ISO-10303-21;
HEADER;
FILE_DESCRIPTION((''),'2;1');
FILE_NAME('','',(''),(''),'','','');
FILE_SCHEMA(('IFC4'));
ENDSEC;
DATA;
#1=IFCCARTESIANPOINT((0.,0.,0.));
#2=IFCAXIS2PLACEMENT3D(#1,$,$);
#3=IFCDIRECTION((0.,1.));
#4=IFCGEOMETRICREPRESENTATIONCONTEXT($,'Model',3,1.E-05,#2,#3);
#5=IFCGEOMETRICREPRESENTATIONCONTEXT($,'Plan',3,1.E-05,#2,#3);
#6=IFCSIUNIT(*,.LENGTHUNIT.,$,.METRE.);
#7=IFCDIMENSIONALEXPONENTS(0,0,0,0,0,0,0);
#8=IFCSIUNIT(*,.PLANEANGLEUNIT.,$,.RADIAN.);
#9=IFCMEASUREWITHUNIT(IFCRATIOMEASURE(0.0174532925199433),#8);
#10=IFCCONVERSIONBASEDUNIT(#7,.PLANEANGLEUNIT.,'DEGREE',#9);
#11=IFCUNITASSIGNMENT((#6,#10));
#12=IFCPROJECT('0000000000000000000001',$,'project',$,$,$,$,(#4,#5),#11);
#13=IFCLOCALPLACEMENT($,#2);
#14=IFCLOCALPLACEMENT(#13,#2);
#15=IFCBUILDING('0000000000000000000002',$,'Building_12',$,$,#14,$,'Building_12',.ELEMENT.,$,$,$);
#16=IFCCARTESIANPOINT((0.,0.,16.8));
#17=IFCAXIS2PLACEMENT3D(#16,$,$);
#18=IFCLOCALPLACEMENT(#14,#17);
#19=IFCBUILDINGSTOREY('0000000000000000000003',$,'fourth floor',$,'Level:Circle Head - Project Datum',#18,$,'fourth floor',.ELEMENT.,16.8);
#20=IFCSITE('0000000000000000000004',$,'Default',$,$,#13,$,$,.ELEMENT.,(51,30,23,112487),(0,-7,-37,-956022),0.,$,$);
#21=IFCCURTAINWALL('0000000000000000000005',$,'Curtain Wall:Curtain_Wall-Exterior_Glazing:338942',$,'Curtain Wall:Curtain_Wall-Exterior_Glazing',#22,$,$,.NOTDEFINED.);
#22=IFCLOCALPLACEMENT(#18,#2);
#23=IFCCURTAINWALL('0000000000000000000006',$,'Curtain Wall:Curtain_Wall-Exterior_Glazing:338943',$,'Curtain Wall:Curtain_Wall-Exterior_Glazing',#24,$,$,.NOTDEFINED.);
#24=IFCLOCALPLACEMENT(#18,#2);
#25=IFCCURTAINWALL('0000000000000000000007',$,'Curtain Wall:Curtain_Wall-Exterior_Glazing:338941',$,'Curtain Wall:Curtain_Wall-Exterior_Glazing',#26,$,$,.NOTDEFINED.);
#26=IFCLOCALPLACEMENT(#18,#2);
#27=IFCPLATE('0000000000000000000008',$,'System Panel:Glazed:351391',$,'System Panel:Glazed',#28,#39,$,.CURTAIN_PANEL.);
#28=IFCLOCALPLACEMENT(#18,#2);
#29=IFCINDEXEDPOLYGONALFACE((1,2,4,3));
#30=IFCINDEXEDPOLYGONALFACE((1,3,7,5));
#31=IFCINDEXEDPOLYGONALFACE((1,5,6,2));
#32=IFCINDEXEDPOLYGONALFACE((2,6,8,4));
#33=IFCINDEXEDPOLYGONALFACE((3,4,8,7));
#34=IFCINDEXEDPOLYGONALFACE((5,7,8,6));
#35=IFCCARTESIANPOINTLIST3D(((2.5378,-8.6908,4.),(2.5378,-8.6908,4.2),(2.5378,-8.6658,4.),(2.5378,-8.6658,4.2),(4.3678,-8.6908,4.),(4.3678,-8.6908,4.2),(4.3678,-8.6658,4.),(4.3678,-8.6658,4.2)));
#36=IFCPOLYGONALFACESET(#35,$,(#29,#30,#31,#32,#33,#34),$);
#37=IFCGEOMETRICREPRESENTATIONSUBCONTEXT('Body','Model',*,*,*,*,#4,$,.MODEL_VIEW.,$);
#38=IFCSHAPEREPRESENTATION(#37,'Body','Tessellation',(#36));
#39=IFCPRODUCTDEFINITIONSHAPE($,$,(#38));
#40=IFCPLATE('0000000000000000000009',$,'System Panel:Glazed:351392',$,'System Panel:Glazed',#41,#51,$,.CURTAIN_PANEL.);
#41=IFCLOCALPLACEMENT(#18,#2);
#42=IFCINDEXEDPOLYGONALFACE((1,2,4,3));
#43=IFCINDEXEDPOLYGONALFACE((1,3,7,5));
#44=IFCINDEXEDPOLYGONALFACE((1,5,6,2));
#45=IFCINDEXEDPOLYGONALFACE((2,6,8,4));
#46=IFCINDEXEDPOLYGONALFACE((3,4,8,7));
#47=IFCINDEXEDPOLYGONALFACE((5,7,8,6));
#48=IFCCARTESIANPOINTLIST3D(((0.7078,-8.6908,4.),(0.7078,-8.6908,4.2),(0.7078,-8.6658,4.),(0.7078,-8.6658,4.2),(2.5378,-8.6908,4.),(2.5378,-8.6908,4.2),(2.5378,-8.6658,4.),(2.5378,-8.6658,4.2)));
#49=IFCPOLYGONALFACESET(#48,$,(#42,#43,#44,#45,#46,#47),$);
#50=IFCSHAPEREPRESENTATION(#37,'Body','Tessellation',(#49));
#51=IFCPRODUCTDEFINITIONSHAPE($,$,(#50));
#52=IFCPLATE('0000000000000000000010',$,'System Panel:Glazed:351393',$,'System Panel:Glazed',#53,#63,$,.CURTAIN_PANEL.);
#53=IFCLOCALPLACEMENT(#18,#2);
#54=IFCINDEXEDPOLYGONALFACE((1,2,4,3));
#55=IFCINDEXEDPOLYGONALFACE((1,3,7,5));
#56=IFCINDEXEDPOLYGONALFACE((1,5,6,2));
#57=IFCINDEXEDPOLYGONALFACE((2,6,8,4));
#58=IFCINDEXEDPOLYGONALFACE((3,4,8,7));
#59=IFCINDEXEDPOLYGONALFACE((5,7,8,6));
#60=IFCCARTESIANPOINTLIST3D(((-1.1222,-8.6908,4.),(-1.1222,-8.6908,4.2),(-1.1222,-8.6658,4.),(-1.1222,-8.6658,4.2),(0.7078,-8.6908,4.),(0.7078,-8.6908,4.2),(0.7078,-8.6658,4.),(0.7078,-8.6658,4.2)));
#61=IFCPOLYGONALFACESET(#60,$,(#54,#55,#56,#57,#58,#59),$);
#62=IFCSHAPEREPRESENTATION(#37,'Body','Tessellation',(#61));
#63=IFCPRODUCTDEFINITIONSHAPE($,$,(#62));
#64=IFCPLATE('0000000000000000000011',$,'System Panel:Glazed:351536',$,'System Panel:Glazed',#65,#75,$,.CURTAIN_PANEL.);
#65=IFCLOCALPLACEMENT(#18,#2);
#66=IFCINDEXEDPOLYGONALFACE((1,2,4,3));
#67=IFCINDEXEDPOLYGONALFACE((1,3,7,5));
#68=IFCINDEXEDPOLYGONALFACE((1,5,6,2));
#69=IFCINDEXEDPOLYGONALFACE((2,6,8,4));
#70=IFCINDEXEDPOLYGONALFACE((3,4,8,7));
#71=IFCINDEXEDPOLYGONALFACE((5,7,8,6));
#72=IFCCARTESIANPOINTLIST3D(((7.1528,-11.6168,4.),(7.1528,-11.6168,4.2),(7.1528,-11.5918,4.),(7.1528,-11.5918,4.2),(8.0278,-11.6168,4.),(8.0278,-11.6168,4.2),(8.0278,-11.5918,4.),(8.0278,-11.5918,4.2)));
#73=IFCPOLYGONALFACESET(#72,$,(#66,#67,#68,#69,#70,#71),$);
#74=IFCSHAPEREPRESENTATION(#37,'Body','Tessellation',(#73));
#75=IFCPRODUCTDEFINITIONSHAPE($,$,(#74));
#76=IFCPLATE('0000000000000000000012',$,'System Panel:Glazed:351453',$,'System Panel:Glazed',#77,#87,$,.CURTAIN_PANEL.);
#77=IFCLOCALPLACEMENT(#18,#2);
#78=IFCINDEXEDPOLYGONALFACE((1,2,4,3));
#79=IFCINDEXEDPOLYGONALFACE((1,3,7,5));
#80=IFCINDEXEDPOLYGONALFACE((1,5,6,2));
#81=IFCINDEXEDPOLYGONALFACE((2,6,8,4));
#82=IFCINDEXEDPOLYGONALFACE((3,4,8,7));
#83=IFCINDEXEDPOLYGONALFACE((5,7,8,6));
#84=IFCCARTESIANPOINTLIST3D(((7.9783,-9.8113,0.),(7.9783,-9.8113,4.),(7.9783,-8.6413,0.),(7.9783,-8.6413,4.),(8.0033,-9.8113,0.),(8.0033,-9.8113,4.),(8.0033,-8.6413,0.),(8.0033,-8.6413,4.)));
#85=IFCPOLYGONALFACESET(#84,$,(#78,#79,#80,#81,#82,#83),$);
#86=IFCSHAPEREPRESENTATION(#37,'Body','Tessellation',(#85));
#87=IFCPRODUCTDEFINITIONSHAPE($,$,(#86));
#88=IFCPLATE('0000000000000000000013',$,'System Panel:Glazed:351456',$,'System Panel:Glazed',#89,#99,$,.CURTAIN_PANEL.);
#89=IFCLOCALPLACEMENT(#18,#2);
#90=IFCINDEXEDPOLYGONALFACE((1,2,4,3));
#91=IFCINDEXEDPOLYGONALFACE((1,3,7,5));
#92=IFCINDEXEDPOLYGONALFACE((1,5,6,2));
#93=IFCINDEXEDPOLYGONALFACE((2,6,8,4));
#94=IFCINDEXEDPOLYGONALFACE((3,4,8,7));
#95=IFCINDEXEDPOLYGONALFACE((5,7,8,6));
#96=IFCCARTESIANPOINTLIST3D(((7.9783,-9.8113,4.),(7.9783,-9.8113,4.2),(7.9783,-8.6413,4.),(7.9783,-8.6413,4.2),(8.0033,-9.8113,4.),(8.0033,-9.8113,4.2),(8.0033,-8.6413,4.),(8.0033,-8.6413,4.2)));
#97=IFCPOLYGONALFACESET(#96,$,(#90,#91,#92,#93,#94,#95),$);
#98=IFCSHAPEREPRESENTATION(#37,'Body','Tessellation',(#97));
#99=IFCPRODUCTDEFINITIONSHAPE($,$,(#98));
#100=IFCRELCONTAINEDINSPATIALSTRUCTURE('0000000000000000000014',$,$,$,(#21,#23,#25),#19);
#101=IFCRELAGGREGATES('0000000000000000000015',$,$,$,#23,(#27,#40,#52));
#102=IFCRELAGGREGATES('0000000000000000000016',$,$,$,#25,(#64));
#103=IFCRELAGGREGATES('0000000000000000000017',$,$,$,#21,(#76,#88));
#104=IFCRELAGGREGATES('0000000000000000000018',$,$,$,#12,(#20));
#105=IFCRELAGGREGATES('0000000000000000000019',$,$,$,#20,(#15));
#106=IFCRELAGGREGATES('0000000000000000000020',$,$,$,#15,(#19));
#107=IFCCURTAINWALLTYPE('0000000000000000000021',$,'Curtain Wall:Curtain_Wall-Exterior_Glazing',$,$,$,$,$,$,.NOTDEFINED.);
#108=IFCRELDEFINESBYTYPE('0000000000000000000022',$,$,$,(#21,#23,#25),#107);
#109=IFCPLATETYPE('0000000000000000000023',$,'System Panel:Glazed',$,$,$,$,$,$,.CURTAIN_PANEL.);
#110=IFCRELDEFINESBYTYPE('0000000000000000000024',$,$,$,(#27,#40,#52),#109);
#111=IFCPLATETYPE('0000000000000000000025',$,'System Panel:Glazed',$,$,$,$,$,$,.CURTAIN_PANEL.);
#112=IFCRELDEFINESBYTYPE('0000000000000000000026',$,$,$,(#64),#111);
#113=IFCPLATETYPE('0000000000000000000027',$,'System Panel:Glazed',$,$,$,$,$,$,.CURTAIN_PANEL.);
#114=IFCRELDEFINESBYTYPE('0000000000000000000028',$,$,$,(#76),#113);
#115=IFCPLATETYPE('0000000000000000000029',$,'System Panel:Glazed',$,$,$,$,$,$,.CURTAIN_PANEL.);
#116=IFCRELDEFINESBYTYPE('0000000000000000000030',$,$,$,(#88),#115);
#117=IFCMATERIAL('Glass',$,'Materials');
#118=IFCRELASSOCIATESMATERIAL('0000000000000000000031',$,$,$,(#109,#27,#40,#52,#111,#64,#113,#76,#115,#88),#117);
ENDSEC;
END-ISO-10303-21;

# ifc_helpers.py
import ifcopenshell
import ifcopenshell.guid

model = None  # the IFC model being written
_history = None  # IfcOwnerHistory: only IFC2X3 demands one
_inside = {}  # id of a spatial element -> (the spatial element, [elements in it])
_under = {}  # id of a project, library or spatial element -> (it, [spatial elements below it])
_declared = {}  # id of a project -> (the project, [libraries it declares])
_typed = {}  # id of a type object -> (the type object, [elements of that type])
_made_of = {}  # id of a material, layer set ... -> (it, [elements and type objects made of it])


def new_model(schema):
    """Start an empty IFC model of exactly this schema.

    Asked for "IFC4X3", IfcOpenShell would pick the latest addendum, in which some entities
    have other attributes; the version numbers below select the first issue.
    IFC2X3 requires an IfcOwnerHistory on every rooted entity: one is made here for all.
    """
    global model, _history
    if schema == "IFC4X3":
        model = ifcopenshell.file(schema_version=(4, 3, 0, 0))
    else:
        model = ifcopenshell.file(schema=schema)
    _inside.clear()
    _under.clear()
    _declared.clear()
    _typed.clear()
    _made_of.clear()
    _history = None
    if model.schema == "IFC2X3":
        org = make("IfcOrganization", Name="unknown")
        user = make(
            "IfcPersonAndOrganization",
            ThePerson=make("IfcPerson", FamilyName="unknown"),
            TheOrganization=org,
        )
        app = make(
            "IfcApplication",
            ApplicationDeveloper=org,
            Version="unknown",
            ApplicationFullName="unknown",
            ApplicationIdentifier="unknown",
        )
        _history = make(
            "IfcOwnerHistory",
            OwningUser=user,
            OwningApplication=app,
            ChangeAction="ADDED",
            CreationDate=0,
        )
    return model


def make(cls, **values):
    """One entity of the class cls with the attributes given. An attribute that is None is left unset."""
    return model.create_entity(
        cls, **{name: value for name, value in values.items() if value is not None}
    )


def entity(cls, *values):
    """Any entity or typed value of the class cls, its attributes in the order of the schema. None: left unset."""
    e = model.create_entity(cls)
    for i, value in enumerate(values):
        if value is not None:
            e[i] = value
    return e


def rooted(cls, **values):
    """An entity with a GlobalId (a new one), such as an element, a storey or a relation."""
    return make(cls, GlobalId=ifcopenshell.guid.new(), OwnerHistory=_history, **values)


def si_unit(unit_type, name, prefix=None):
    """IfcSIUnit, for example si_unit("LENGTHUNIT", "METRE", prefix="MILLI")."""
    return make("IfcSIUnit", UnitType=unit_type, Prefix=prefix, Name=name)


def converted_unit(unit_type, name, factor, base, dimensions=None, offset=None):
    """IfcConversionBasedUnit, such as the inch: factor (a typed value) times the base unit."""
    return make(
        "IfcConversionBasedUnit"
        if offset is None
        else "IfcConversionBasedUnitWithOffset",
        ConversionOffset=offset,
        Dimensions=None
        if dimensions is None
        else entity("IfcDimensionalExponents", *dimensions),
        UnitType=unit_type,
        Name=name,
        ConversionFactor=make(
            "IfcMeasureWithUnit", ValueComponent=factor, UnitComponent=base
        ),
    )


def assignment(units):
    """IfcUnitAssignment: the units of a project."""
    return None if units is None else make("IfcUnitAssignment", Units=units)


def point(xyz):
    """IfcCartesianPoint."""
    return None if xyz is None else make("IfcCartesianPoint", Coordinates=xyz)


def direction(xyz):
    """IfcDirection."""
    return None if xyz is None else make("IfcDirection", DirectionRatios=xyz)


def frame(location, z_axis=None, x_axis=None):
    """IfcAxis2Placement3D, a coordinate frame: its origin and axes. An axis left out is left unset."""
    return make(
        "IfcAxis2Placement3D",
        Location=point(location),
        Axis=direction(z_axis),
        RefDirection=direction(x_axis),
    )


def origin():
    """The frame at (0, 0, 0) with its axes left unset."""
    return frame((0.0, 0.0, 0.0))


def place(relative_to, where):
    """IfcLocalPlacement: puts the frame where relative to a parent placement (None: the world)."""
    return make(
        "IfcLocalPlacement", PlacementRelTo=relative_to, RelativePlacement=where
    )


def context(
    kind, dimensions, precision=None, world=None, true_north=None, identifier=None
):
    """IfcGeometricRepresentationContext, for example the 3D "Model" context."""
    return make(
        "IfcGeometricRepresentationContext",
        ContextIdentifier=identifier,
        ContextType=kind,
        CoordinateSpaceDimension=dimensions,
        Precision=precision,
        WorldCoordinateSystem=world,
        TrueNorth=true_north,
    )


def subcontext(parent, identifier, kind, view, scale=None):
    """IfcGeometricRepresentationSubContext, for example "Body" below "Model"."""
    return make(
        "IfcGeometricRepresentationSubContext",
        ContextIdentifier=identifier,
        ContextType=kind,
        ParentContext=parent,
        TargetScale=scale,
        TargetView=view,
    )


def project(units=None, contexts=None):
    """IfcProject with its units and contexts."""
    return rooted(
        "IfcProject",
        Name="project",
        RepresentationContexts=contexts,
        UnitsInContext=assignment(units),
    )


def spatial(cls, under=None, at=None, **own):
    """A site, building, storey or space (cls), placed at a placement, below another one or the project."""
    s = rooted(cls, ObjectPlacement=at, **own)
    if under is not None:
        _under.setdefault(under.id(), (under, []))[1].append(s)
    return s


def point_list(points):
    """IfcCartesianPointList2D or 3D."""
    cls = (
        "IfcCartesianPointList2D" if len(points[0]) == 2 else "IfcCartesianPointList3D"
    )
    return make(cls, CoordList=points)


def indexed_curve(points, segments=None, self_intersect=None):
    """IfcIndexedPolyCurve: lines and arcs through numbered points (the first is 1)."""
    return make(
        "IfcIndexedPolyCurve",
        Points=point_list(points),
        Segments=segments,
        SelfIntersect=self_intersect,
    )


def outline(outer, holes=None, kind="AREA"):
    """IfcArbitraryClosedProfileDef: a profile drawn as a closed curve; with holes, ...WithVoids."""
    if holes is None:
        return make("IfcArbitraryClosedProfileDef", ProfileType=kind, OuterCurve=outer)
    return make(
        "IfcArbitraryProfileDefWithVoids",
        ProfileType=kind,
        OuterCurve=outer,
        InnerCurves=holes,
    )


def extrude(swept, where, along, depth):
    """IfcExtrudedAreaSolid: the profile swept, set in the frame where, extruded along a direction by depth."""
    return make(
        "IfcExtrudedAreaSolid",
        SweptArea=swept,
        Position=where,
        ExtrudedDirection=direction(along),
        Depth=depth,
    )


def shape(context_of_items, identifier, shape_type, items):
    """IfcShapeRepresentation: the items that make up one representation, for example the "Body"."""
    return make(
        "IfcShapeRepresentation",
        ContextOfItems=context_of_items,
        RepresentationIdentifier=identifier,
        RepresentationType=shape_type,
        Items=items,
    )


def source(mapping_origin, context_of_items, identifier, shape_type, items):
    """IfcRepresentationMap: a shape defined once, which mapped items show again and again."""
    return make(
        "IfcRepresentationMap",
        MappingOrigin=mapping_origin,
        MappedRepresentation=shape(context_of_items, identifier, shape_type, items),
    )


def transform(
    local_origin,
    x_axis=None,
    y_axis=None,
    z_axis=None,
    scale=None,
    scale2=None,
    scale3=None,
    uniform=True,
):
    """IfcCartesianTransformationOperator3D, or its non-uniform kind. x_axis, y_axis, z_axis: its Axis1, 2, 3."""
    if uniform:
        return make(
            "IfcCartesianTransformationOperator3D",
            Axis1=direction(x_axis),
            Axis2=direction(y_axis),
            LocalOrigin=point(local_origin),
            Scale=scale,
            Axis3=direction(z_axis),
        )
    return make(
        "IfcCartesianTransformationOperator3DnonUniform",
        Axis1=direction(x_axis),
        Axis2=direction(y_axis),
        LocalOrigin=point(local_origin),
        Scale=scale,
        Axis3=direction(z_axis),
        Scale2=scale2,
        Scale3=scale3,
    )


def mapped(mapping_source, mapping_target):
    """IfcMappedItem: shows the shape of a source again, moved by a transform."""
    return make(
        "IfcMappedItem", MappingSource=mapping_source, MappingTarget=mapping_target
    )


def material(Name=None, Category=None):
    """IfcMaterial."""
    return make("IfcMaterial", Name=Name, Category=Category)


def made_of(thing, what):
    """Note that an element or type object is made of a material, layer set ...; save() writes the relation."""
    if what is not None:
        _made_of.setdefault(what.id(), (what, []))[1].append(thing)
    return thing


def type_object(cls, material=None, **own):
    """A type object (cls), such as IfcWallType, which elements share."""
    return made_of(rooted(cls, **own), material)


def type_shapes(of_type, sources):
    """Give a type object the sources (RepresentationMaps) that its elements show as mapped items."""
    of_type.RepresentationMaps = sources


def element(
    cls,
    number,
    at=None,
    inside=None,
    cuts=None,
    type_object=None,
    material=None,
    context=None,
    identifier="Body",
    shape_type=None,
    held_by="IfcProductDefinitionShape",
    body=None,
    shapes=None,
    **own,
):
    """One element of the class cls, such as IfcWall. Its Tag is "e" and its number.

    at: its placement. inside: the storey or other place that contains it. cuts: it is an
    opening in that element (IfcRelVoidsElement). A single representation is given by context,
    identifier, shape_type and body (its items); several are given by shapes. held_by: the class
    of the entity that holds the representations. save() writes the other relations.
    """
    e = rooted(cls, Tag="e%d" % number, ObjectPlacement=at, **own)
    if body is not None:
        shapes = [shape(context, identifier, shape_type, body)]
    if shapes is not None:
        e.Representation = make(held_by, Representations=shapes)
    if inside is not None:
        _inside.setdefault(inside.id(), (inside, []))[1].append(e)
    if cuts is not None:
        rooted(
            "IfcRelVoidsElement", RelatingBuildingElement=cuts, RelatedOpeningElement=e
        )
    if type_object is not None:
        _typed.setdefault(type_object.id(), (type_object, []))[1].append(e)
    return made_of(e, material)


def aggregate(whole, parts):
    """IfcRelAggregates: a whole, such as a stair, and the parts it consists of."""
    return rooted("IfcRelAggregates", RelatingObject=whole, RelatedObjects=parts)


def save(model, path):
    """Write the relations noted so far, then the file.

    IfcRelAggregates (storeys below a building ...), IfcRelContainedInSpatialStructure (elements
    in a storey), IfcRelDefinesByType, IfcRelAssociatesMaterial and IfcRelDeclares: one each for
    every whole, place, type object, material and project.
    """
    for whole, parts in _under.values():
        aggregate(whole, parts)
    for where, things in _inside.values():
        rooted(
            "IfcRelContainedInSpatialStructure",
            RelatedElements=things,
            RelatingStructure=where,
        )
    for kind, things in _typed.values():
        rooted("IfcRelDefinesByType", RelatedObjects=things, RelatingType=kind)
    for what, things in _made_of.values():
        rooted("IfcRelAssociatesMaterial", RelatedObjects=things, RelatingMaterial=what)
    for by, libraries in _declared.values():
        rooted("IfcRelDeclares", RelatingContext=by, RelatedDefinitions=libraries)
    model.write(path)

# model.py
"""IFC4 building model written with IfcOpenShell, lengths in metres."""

from ifc_helpers import new_model, entity, si_unit, converted_unit, direction, frame, origin, place, context, subcontext, project, spatial, indexed_curve, outline, extrude, source, transform, mapped, material, type_object, type_shapes, element, aggregate, save


model = new_model("IFC4")

# Units and contexts
model_context = context("Model", 3, precision=1e-05, world=origin(), true_north=direction((0.0, 1.0)))
plan_context = context("Plan", 3, precision=1e-05, world=origin(), true_north=direction((0.0, 1.0)))
body_context = subcontext(model_context, "Body", "Model", "MODEL_VIEW")
ifc_project = project(units=[si_unit("LENGTHUNIT", "METRE"), converted_unit("PLANEANGLEUNIT", "DEGREE", entity("IfcRatioMeasure", 0.0174532925199433), si_unit("PLANEANGLEUNIT", "RADIAN"), dimensions=[0, 0, 0, 0, 0, 0, 0])], contexts=[model_context, plan_context])

# Site, building, storey
site_placement = place(None, origin())
site = spatial("IfcSite", under=ifc_project, at=site_placement, Name="Default", CompositionType="ELEMENT", RefLatitude=(51, 30, 23, 112487), RefLongitude=(0, -7, -37, -956022), RefElevation=0.0)
building_placement = place(site_placement, origin())
building = spatial("IfcBuilding", under=site, at=building_placement, Name="Building_12", LongName="Building_12", CompositionType="ELEMENT")
storey_placement = place(building_placement, frame((0.0, 0.0, 16.8)))
storey = spatial("IfcBuildingStorey", under=building, at=storey_placement, Name="fourth floor", ObjectType="Level:Circle Head - Project Datum", LongName="fourth floor", CompositionType="ELEMENT", Elevation=16.8)

# Curtain wall
curtain_wall_type = type_object("IfcCurtainWallType", Name="Curtain Wall:Curtain_Wall-Exterior_Glazing", PredefinedType="NOTDEFINED")
curtain_wall_1_placement = place(storey_placement, frame((0.0, 0.0, -16.8)))
curtain_wall_1 = element("IfcCurtainWall", 1, at=curtain_wall_1_placement, inside=storey, type_object=curtain_wall_type, Name="Curtain Wall:Curtain_Wall-Exterior_Glazing:338942", ObjectType="Curtain Wall:Curtain_Wall-Exterior_Glazing", PredefinedType="NOTDEFINED")
ifc_material = material(Name="Glass", Category="Materials")

# Curtain walls
curtain_wall_2_placement = place(storey_placement, frame((0.0, 0.0, -16.8)))
curtain_wall_2 = element("IfcCurtainWall", 2, at=curtain_wall_2_placement, inside=storey, type_object=curtain_wall_type, Name="Curtain Wall:Curtain_Wall-Exterior_Glazing:338943", ObjectType="Curtain Wall:Curtain_Wall-Exterior_Glazing", PredefinedType="NOTDEFINED")
curtain_wall_3_placement = place(storey_placement, frame((0.0, 0.0, -16.8)))
curtain_wall_3 = element("IfcCurtainWall", 3, at=curtain_wall_3_placement, inside=storey, type_object=curtain_wall_type, Name="Curtain Wall:Curtain_Wall-Exterior_Glazing:338941", ObjectType="Curtain Wall:Curtain_Wall-Exterior_Glazing", PredefinedType="NOTDEFINED")
plate_type_1 = type_object("IfcPlateType", Name="System Panel:Glazed", PredefinedType="CURTAIN_PANEL", material=ifc_material)
shared_shape_1 = source(origin(), body_context, "Body", "SweptSolid", [
    extrude(outline(indexed_curve([(-0.0125, -0.915), (0.0125, -0.915), (0.0125, 0.915), (-0.0125, 0.915), (-0.0125, -0.915)], self_intersect=False)), frame((0.0, 0.037, 0.0), z_axis=(0.0, 0.0, 1.0), x_axis=(0.0, 1.0, 0.0)), (0.0, 0.0, 1.0), 0.2),
])
type_shapes(plate_type_1, [shared_shape_1])

# Plates
plate_1_placement = place(curtain_wall_2_placement, frame((3.4528, -8.6413, 20.8), z_axis=(0.0, 0.0, 1.0), x_axis=(-1.0, 0.0, 0.0)))
plate_1 = element("IfcPlate", 4, at=plate_1_placement, type_object=plate_type_1, material=ifc_material, Name="System Panel:Glazed:351391", ObjectType="System Panel:Glazed", PredefinedType="CURTAIN_PANEL", context=body_context, shape_type="MappedRepresentation", body=[
    mapped(shared_shape_1, transform((0.0, 0.0, 0.0), scale=1.0)),
])
plate_2_placement = place(curtain_wall_2_placement, frame((1.6228, -8.6413, 20.8), z_axis=(0.0, 0.0, 1.0), x_axis=(-1.0, 0.0, 0.0)))
plate_2 = element("IfcPlate", 5, at=plate_2_placement, type_object=plate_type_1, material=ifc_material, Name="System Panel:Glazed:351392", ObjectType="System Panel:Glazed", PredefinedType="CURTAIN_PANEL", context=body_context, shape_type="MappedRepresentation", body=[
    mapped(shared_shape_1, transform((0.0, 0.0, 0.0), scale=1.0)),
])
plate_3_placement = place(curtain_wall_2_placement, frame((-0.2072, -8.6413, 20.8), z_axis=(0.0, 0.0, 1.0), x_axis=(-1.0, 0.0, 0.0)))
plate_3 = element("IfcPlate", 6, at=plate_3_placement, type_object=plate_type_1, material=ifc_material, Name="System Panel:Glazed:351393", ObjectType="System Panel:Glazed", PredefinedType="CURTAIN_PANEL", context=body_context, shape_type="MappedRepresentation", body=[
    mapped(shared_shape_1, transform((0.0, 0.0, 0.0), scale=1.0)),
])
aggregate(curtain_wall_2, [plate_1, plate_2, plate_3])
plate_type_2 = type_object("IfcPlateType", Name="System Panel:Glazed", PredefinedType="CURTAIN_PANEL", material=ifc_material)
shared_shape_2 = source(origin(), body_context, "Body", "SweptSolid", [
    extrude(outline(indexed_curve([(-0.0125, -0.4375), (0.0125, -0.4375), (0.0125, 0.4375), (-0.0125, 0.4375), (-0.0125, -0.4375)], self_intersect=False)), frame((0.0, 0.037, 0.0), z_axis=(0.0, 0.0, 1.0), x_axis=(0.0, 1.0, 0.0)), (0.0, 0.0, 1.0), 0.2),
])
type_shapes(plate_type_2, [shared_shape_2])
plate_4_placement = place(curtain_wall_3_placement, frame((7.5903, -11.6413, 20.8)))
plate_4 = element("IfcPlate", 7, at=plate_4_placement, type_object=plate_type_2, material=ifc_material, Name="System Panel:Glazed:351536", ObjectType="System Panel:Glazed", PredefinedType="CURTAIN_PANEL", context=body_context, shape_type="MappedRepresentation", body=[
    mapped(shared_shape_2, transform((0.0, 0.0, 0.0), scale=1.0)),
])
aggregate(curtain_wall_3, [plate_4])
plate_type_3 = type_object("IfcPlateType", Name="System Panel:Glazed", PredefinedType="CURTAIN_PANEL", material=ifc_material)
shared_shape_3 = source(origin(), body_context, "Body", "SweptSolid", [
    extrude(outline(indexed_curve([(-0.0125, -0.585), (0.0125, -0.585), (0.0125, 0.585), (-0.0125, 0.585), (-0.0125, -0.585)], self_intersect=False)), frame((0.0, 0.037, 0.0), z_axis=(0.0, 0.0, 1.0), x_axis=(0.0, 1.0, 0.0)), (0.0, 0.0, 1.0), 4.0),
])
type_shapes(plate_type_3, [shared_shape_3])
plate_5_placement = place(curtain_wall_1_placement, frame((8.0278, -9.2263, 16.8), z_axis=(0.0, 0.0, 1.0), x_axis=(0.0, 1.0, 0.0)))
plate_5 = element("IfcPlate", 8, at=plate_5_placement, type_object=plate_type_3, material=ifc_material, Name="System Panel:Glazed:351453", ObjectType="System Panel:Glazed", PredefinedType="CURTAIN_PANEL", context=body_context, shape_type="MappedRepresentation", body=[
    mapped(shared_shape_3, transform((0.0, 0.0, 0.0), scale=1.0)),
])
plate_type_4 = type_object("IfcPlateType", Name="System Panel:Glazed", PredefinedType="CURTAIN_PANEL", material=ifc_material)
shared_shape_4 = source(origin(), body_context, "Body", "SweptSolid", [
    extrude(outline(indexed_curve([(-0.0125, -0.585), (0.0125, -0.585), (0.0125, 0.585), (-0.0125, 0.585), (-0.0125, -0.585)], self_intersect=False)), frame((0.0, 0.037, 0.0), z_axis=(0.0, 0.0, 1.0), x_axis=(0.0, 1.0, 0.0)), (0.0, 0.0, 1.0), 0.2),
])
type_shapes(plate_type_4, [shared_shape_4])
plate_6_placement = place(curtain_wall_1_placement, frame((8.0278, -9.2263, 20.8), z_axis=(0.0, 0.0, 1.0), x_axis=(0.0, 1.0, 0.0)))
plate_6 = element("IfcPlate", 9, at=plate_6_placement, type_object=plate_type_4, material=ifc_material, Name="System Panel:Glazed:351456", ObjectType="System Panel:Glazed", PredefinedType="CURTAIN_PANEL", context=body_context, shape_type="MappedRepresentation", body=[
    mapped(shared_shape_4, transform((0.0, 0.0, 0.0), scale=1.0)),
])
aggregate(curtain_wall_1, [plate_5, plate_6])

save(model, "model.ifc")
